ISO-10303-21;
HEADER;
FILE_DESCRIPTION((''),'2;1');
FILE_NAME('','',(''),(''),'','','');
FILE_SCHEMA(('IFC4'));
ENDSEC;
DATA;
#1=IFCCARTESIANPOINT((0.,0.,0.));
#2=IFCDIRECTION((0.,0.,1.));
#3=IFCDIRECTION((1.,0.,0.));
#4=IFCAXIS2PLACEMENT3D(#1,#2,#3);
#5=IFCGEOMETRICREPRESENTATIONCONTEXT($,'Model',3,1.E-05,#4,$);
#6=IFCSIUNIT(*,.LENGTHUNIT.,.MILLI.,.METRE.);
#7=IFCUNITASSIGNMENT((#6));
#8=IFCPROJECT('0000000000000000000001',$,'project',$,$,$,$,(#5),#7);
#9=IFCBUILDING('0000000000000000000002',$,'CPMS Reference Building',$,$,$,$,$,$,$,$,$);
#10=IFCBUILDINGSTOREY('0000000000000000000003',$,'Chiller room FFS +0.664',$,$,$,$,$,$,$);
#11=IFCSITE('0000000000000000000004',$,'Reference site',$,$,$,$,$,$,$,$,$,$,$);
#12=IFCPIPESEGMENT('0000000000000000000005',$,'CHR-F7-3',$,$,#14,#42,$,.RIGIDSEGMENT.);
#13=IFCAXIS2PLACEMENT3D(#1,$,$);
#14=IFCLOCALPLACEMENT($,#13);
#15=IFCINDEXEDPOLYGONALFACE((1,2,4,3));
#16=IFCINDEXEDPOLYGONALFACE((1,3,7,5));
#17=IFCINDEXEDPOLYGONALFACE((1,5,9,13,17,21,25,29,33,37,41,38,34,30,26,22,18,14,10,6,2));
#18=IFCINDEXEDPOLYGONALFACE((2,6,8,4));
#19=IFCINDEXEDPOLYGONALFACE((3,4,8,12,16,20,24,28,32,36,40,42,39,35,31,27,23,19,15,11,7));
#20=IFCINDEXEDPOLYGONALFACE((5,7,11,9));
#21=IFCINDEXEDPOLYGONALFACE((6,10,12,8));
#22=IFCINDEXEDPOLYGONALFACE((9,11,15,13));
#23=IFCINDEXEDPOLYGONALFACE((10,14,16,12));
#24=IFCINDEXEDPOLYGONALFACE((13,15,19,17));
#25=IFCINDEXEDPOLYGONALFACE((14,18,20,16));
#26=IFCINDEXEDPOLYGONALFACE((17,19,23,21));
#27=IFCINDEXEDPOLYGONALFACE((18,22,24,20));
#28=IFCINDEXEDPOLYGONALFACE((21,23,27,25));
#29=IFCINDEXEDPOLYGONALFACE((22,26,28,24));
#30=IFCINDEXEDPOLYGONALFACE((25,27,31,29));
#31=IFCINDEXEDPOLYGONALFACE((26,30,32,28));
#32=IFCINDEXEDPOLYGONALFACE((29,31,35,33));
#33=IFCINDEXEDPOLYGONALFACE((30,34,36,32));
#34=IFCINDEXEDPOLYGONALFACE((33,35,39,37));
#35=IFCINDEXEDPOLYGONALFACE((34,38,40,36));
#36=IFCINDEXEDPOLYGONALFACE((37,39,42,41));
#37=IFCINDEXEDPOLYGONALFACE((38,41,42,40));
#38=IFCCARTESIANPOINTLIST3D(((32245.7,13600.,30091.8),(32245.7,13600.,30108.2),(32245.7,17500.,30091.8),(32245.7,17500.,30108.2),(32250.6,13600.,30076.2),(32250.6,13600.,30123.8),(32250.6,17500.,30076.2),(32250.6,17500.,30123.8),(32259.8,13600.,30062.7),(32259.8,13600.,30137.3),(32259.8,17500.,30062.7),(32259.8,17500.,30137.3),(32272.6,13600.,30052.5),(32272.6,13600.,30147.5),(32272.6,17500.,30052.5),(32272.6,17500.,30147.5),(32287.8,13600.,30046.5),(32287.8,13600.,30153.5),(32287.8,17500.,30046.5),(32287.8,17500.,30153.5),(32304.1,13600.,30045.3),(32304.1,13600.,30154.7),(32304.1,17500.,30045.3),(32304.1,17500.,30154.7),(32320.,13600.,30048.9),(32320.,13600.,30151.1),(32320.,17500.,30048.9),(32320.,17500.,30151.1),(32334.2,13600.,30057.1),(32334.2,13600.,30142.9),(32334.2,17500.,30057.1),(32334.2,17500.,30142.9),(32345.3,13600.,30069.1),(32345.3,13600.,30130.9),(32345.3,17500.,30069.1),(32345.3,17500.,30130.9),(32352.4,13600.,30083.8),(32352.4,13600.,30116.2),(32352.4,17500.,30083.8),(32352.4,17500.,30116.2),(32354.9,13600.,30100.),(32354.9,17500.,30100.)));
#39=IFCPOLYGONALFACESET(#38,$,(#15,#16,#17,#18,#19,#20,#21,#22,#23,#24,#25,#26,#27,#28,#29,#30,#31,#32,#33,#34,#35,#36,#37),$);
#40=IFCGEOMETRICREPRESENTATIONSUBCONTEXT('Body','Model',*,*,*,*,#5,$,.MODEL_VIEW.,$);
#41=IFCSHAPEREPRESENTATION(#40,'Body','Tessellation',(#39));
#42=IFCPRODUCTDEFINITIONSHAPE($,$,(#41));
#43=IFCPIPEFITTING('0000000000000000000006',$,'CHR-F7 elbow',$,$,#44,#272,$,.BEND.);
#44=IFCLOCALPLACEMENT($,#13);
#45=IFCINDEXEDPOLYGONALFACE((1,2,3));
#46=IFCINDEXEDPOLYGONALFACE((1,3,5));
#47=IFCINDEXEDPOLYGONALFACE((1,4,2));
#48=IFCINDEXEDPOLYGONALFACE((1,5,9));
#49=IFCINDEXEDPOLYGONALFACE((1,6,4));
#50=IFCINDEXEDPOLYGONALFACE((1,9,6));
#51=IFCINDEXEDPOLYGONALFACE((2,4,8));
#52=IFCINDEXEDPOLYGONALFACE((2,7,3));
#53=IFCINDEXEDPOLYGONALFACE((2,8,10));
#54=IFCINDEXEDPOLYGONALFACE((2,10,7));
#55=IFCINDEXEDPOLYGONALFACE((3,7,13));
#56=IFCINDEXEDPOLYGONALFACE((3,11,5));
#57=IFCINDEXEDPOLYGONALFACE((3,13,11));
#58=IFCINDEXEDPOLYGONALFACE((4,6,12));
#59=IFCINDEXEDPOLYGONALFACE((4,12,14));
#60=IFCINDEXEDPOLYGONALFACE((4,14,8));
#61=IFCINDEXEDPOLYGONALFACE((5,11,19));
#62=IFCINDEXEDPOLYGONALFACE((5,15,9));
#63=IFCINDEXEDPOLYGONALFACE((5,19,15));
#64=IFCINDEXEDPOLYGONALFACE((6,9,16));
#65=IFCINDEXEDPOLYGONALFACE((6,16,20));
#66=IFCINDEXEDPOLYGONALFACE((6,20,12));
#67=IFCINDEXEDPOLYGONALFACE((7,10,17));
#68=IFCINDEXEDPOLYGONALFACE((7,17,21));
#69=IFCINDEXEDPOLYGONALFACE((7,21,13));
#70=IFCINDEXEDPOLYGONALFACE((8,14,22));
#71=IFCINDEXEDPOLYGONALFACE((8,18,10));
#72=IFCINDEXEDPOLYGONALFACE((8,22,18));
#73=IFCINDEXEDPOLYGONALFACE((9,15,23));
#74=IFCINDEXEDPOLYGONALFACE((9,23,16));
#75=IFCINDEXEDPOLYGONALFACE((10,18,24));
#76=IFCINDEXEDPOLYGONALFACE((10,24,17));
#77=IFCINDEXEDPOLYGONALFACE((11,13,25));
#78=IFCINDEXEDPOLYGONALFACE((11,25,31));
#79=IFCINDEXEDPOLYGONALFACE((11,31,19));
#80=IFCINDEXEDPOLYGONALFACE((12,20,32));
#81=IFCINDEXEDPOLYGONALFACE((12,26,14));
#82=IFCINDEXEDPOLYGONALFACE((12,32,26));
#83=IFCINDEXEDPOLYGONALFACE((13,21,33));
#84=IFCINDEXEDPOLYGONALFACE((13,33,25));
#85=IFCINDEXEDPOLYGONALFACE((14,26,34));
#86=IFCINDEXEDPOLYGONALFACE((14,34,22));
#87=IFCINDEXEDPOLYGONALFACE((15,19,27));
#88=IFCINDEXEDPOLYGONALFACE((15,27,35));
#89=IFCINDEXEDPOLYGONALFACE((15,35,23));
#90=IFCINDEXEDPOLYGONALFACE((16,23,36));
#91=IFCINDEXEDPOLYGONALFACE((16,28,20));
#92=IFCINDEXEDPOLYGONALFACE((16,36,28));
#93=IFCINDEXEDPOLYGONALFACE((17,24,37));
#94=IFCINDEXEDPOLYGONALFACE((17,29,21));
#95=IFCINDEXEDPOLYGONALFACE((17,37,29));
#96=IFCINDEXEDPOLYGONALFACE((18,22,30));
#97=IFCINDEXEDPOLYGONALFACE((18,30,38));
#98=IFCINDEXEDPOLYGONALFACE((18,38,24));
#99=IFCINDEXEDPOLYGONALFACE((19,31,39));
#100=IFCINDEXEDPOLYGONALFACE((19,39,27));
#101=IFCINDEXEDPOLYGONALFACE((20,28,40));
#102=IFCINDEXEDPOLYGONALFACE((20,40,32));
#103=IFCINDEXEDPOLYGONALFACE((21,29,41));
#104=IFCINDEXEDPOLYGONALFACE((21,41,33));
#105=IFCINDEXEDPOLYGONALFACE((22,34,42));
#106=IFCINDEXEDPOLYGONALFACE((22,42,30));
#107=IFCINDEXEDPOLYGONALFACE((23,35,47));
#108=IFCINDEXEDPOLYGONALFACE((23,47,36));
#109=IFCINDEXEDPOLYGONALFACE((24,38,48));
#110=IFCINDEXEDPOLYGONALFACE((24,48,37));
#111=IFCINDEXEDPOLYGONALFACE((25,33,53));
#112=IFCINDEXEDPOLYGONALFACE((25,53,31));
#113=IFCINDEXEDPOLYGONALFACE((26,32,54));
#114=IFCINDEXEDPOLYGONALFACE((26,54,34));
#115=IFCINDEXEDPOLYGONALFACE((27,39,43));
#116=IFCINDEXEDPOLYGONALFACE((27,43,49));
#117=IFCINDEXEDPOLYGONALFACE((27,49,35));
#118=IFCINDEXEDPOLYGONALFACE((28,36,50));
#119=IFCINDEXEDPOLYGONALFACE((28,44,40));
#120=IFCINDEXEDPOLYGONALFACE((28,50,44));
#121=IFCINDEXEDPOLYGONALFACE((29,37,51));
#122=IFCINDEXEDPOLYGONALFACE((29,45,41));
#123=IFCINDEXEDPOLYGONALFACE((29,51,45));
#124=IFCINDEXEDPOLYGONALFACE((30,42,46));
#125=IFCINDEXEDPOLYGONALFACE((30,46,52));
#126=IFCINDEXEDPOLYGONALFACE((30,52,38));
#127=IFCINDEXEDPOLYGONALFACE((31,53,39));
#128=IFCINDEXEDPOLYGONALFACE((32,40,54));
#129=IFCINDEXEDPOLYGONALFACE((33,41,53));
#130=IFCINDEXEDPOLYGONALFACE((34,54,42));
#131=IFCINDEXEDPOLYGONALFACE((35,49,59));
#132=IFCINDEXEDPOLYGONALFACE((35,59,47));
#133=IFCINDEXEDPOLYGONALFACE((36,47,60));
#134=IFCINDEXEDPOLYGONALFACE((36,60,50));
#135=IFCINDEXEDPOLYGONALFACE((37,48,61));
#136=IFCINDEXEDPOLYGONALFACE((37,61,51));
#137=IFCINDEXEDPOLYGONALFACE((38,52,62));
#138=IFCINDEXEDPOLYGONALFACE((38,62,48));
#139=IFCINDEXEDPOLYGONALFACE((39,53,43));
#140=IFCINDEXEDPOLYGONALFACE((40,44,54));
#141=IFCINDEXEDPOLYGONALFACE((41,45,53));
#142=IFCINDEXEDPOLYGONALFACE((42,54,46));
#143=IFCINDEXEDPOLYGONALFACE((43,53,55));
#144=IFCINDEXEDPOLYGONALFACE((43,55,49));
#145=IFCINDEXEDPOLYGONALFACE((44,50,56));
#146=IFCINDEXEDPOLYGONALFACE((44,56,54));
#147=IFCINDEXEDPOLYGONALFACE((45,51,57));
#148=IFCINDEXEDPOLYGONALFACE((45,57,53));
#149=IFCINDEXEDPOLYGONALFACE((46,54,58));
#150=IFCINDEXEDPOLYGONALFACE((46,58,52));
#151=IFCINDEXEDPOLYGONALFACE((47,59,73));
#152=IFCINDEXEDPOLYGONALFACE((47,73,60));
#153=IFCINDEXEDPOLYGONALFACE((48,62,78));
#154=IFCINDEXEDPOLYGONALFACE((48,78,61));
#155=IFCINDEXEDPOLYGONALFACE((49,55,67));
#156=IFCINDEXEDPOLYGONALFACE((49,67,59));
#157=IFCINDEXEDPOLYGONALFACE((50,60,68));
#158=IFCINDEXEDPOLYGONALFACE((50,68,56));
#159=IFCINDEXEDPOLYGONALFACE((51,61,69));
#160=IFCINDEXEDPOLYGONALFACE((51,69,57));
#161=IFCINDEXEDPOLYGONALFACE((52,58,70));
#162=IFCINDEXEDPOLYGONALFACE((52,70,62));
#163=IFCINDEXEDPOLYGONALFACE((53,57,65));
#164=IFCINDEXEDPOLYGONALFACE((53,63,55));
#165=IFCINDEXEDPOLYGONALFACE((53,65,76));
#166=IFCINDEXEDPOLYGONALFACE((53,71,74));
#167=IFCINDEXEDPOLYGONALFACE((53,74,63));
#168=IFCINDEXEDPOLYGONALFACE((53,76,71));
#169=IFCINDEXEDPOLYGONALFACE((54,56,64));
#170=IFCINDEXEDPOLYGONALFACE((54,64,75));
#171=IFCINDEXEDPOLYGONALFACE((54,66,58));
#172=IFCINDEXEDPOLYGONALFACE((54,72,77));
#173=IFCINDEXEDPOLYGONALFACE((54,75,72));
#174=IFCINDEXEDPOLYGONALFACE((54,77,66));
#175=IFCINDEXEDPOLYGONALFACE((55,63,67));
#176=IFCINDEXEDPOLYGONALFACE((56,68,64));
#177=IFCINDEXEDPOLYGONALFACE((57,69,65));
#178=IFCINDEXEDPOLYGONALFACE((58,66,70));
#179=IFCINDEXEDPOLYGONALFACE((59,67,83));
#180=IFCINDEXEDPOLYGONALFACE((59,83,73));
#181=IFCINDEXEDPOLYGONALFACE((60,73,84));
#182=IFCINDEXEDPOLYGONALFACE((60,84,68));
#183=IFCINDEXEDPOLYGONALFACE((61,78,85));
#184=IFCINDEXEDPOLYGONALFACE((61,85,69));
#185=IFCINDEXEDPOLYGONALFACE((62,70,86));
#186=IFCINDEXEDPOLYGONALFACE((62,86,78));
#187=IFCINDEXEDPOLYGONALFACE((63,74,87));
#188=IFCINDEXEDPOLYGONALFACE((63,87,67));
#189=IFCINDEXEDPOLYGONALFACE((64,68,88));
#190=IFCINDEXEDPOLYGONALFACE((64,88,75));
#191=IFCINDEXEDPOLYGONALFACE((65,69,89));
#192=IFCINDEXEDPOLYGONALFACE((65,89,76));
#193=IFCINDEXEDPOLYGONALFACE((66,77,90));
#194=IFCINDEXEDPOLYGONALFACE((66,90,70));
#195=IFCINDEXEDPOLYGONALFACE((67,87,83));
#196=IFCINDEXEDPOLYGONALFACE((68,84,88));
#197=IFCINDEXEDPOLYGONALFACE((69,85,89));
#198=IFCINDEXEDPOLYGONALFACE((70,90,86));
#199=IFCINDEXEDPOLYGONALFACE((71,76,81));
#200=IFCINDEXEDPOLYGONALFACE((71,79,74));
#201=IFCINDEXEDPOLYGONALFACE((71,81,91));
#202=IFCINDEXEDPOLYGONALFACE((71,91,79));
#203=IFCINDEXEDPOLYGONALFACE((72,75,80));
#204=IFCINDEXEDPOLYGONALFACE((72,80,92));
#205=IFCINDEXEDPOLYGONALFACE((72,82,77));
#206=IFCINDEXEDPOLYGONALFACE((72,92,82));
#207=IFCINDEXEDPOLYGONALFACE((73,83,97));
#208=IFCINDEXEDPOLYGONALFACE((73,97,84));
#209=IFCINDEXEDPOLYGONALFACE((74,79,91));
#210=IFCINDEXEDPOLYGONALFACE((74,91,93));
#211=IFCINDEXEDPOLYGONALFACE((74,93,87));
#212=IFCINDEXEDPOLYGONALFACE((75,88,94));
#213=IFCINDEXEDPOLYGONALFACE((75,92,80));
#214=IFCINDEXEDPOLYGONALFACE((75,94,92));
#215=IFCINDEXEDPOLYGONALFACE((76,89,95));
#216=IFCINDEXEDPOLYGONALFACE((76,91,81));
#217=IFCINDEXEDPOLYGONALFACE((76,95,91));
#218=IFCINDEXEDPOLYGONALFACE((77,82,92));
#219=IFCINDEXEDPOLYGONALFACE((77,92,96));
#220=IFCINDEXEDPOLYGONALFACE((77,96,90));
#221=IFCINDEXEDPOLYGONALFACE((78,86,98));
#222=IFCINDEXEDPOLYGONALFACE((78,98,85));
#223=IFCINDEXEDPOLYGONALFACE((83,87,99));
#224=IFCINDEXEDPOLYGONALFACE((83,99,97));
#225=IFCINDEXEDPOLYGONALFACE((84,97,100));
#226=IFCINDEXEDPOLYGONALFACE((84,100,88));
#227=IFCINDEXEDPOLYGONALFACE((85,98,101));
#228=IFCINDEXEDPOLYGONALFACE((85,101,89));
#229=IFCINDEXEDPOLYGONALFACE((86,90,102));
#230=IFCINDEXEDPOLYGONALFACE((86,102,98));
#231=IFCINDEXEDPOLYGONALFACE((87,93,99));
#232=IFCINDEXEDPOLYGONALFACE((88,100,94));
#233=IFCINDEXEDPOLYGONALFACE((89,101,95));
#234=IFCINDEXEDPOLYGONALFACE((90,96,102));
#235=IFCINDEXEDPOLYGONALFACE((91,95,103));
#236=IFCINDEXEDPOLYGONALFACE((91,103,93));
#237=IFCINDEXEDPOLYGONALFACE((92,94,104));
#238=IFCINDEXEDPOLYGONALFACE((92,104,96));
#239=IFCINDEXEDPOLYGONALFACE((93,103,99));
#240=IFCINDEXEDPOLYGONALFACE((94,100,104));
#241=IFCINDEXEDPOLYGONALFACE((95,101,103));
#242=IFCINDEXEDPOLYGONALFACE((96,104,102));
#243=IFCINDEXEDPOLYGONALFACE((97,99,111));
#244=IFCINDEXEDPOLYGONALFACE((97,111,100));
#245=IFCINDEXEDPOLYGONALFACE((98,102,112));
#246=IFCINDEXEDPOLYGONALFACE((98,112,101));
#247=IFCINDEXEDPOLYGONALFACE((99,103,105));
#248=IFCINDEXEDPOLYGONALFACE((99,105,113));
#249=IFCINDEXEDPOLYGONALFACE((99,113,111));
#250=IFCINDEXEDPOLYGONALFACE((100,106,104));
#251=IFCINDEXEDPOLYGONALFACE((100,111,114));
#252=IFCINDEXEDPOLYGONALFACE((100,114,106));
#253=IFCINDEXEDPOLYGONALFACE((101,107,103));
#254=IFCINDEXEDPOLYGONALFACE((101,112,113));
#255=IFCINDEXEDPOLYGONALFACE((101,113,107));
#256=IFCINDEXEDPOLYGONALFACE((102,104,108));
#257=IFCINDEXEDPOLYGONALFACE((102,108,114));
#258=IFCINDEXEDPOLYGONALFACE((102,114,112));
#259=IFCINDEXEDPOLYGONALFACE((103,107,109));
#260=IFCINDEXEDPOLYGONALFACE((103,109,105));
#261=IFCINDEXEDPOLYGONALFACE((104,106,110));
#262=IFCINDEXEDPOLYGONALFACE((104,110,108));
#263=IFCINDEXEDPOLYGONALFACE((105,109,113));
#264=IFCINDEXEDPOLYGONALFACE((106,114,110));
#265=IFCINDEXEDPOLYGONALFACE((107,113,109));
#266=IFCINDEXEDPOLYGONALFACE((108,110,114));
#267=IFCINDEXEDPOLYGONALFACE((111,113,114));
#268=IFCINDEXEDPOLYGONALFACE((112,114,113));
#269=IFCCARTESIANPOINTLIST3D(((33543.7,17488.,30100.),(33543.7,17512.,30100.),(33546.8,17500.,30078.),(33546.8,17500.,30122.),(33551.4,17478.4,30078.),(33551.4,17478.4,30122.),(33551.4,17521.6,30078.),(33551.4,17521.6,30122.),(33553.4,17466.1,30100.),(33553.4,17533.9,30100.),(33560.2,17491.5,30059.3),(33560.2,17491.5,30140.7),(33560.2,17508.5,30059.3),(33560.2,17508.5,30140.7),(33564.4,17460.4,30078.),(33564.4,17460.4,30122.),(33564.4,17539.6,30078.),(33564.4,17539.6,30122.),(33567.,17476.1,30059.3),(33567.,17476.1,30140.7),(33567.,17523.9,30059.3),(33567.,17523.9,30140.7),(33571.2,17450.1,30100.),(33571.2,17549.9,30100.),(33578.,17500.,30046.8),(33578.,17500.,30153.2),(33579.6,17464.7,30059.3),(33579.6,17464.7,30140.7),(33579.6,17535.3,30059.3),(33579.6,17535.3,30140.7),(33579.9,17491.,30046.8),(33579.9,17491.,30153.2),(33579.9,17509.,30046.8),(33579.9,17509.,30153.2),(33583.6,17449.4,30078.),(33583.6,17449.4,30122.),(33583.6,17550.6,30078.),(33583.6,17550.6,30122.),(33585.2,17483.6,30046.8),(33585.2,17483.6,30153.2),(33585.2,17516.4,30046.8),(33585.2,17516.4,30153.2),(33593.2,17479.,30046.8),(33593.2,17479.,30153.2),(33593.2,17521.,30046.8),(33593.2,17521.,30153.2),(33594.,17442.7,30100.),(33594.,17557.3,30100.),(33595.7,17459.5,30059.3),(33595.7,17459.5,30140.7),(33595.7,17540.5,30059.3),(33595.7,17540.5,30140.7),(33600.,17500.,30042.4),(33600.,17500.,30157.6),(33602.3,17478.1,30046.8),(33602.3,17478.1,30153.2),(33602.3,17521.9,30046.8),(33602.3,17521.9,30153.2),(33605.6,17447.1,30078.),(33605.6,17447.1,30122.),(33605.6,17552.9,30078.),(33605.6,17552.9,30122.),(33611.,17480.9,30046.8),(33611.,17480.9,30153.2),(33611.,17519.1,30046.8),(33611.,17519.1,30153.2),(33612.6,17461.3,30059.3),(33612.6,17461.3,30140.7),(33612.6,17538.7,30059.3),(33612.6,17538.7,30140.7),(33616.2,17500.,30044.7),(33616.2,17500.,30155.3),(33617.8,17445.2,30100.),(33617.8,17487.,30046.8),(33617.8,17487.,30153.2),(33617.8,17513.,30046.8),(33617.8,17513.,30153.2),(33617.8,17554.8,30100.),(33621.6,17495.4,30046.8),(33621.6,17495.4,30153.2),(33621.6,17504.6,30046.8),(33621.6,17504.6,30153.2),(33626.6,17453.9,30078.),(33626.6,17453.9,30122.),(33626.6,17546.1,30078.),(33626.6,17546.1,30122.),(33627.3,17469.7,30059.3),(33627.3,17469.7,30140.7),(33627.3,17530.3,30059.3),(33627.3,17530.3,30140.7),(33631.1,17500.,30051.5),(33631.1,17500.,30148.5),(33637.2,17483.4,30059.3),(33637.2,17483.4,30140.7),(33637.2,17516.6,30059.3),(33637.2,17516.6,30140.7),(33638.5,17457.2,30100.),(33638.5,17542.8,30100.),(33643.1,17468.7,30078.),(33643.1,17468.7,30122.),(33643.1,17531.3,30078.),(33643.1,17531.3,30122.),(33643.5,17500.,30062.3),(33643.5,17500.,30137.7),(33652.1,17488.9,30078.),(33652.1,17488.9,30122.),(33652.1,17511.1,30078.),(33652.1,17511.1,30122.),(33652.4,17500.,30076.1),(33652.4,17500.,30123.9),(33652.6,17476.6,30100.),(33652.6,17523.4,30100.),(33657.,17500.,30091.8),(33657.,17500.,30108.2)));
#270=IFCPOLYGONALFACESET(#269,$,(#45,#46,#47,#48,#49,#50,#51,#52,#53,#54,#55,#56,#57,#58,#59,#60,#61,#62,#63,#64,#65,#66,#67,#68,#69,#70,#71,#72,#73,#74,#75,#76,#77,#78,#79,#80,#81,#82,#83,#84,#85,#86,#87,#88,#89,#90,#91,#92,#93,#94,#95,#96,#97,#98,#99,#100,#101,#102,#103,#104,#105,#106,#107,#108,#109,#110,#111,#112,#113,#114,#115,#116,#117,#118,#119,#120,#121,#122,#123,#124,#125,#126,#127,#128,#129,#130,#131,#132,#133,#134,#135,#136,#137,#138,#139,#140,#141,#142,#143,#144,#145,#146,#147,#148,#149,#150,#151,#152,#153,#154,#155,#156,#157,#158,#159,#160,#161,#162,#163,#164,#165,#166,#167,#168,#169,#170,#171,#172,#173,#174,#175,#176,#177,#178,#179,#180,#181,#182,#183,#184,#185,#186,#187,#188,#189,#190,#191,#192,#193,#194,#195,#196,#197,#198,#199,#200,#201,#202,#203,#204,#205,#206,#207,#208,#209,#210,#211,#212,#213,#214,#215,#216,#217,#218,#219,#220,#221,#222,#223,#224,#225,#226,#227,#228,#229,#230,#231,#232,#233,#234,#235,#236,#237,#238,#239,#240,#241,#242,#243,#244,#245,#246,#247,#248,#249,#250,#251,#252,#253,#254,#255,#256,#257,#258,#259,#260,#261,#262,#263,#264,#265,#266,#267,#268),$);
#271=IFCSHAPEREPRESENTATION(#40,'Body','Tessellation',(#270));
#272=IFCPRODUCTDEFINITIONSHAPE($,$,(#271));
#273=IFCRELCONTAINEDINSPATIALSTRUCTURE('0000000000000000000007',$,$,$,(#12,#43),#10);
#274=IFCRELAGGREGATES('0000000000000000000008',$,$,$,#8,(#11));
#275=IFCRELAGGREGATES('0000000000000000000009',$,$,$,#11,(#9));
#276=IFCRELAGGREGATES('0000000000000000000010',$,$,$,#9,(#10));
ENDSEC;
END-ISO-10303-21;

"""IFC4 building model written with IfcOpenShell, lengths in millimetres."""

from ifc_helpers import new_model, entity, si_unit, frame, origin_with_axes, origin_2d, place, context, subcontext, project, spatial, circle_curve, outline, extrude, element, save


model = new_model("IFC4")

# Units and contexts
model_context = context("Model", 3, precision=1e-05, world=origin_with_axes())
body_context = subcontext(model_context, "Body", "Model", "MODEL_VIEW")
ifc_project = project(units=[si_unit("LENGTHUNIT", "METRE", prefix="MILLI")], contexts=[model_context])

# Site, building, storey
site = spatial("IfcSite", under=ifc_project, Name="Reference site")
building = spatial("IfcBuilding", under=site, Name="CPMS Reference Building")
storey = spatial("IfcBuildingStorey", under=building, Name="Chiller room FFS +0.664")

# Pipe segment
pipe_segment_1_placement = place(None, origin_with_axes())
element("IfcPipeSegment", 1, at=pipe_segment_1_placement, inside=storey, Name="CHR-F7-3", PredefinedType="RIGIDSEGMENT", context=body_context, shape_type="SweptSolid", body=[
    extrude(outline(circle_curve(origin_2d(), 54.9)), frame((32300.0, 17500.0, 30100.0), z_axis=(0.0, -1.0, 0.0), x_axis=(1.0, 0.0, 0.0)), (0.0, 0.0, 1.0), 3900.0),
])

# Pipe fitting
pipe_fitting_1_placement = place(None, origin_with_axes())
element("IfcPipeFitting", 2, at=pipe_fitting_1_placement, inside=storey, Name="CHR-F7 elbow", PredefinedType="BEND", context=body_context, shape_type="CSG", body=[
    entity("IfcSphere", entity("IfcAxis2Placement3D", entity("IfcCartesianPoint", [33600.0, 17500.0, 30100.0]), entity("IfcDirection", [0.0, 0.0, 1.0]), entity("IfcDirection", [1.0, 0.0, 0.0])), 57.6),
])

save(model, "model.ifc")
